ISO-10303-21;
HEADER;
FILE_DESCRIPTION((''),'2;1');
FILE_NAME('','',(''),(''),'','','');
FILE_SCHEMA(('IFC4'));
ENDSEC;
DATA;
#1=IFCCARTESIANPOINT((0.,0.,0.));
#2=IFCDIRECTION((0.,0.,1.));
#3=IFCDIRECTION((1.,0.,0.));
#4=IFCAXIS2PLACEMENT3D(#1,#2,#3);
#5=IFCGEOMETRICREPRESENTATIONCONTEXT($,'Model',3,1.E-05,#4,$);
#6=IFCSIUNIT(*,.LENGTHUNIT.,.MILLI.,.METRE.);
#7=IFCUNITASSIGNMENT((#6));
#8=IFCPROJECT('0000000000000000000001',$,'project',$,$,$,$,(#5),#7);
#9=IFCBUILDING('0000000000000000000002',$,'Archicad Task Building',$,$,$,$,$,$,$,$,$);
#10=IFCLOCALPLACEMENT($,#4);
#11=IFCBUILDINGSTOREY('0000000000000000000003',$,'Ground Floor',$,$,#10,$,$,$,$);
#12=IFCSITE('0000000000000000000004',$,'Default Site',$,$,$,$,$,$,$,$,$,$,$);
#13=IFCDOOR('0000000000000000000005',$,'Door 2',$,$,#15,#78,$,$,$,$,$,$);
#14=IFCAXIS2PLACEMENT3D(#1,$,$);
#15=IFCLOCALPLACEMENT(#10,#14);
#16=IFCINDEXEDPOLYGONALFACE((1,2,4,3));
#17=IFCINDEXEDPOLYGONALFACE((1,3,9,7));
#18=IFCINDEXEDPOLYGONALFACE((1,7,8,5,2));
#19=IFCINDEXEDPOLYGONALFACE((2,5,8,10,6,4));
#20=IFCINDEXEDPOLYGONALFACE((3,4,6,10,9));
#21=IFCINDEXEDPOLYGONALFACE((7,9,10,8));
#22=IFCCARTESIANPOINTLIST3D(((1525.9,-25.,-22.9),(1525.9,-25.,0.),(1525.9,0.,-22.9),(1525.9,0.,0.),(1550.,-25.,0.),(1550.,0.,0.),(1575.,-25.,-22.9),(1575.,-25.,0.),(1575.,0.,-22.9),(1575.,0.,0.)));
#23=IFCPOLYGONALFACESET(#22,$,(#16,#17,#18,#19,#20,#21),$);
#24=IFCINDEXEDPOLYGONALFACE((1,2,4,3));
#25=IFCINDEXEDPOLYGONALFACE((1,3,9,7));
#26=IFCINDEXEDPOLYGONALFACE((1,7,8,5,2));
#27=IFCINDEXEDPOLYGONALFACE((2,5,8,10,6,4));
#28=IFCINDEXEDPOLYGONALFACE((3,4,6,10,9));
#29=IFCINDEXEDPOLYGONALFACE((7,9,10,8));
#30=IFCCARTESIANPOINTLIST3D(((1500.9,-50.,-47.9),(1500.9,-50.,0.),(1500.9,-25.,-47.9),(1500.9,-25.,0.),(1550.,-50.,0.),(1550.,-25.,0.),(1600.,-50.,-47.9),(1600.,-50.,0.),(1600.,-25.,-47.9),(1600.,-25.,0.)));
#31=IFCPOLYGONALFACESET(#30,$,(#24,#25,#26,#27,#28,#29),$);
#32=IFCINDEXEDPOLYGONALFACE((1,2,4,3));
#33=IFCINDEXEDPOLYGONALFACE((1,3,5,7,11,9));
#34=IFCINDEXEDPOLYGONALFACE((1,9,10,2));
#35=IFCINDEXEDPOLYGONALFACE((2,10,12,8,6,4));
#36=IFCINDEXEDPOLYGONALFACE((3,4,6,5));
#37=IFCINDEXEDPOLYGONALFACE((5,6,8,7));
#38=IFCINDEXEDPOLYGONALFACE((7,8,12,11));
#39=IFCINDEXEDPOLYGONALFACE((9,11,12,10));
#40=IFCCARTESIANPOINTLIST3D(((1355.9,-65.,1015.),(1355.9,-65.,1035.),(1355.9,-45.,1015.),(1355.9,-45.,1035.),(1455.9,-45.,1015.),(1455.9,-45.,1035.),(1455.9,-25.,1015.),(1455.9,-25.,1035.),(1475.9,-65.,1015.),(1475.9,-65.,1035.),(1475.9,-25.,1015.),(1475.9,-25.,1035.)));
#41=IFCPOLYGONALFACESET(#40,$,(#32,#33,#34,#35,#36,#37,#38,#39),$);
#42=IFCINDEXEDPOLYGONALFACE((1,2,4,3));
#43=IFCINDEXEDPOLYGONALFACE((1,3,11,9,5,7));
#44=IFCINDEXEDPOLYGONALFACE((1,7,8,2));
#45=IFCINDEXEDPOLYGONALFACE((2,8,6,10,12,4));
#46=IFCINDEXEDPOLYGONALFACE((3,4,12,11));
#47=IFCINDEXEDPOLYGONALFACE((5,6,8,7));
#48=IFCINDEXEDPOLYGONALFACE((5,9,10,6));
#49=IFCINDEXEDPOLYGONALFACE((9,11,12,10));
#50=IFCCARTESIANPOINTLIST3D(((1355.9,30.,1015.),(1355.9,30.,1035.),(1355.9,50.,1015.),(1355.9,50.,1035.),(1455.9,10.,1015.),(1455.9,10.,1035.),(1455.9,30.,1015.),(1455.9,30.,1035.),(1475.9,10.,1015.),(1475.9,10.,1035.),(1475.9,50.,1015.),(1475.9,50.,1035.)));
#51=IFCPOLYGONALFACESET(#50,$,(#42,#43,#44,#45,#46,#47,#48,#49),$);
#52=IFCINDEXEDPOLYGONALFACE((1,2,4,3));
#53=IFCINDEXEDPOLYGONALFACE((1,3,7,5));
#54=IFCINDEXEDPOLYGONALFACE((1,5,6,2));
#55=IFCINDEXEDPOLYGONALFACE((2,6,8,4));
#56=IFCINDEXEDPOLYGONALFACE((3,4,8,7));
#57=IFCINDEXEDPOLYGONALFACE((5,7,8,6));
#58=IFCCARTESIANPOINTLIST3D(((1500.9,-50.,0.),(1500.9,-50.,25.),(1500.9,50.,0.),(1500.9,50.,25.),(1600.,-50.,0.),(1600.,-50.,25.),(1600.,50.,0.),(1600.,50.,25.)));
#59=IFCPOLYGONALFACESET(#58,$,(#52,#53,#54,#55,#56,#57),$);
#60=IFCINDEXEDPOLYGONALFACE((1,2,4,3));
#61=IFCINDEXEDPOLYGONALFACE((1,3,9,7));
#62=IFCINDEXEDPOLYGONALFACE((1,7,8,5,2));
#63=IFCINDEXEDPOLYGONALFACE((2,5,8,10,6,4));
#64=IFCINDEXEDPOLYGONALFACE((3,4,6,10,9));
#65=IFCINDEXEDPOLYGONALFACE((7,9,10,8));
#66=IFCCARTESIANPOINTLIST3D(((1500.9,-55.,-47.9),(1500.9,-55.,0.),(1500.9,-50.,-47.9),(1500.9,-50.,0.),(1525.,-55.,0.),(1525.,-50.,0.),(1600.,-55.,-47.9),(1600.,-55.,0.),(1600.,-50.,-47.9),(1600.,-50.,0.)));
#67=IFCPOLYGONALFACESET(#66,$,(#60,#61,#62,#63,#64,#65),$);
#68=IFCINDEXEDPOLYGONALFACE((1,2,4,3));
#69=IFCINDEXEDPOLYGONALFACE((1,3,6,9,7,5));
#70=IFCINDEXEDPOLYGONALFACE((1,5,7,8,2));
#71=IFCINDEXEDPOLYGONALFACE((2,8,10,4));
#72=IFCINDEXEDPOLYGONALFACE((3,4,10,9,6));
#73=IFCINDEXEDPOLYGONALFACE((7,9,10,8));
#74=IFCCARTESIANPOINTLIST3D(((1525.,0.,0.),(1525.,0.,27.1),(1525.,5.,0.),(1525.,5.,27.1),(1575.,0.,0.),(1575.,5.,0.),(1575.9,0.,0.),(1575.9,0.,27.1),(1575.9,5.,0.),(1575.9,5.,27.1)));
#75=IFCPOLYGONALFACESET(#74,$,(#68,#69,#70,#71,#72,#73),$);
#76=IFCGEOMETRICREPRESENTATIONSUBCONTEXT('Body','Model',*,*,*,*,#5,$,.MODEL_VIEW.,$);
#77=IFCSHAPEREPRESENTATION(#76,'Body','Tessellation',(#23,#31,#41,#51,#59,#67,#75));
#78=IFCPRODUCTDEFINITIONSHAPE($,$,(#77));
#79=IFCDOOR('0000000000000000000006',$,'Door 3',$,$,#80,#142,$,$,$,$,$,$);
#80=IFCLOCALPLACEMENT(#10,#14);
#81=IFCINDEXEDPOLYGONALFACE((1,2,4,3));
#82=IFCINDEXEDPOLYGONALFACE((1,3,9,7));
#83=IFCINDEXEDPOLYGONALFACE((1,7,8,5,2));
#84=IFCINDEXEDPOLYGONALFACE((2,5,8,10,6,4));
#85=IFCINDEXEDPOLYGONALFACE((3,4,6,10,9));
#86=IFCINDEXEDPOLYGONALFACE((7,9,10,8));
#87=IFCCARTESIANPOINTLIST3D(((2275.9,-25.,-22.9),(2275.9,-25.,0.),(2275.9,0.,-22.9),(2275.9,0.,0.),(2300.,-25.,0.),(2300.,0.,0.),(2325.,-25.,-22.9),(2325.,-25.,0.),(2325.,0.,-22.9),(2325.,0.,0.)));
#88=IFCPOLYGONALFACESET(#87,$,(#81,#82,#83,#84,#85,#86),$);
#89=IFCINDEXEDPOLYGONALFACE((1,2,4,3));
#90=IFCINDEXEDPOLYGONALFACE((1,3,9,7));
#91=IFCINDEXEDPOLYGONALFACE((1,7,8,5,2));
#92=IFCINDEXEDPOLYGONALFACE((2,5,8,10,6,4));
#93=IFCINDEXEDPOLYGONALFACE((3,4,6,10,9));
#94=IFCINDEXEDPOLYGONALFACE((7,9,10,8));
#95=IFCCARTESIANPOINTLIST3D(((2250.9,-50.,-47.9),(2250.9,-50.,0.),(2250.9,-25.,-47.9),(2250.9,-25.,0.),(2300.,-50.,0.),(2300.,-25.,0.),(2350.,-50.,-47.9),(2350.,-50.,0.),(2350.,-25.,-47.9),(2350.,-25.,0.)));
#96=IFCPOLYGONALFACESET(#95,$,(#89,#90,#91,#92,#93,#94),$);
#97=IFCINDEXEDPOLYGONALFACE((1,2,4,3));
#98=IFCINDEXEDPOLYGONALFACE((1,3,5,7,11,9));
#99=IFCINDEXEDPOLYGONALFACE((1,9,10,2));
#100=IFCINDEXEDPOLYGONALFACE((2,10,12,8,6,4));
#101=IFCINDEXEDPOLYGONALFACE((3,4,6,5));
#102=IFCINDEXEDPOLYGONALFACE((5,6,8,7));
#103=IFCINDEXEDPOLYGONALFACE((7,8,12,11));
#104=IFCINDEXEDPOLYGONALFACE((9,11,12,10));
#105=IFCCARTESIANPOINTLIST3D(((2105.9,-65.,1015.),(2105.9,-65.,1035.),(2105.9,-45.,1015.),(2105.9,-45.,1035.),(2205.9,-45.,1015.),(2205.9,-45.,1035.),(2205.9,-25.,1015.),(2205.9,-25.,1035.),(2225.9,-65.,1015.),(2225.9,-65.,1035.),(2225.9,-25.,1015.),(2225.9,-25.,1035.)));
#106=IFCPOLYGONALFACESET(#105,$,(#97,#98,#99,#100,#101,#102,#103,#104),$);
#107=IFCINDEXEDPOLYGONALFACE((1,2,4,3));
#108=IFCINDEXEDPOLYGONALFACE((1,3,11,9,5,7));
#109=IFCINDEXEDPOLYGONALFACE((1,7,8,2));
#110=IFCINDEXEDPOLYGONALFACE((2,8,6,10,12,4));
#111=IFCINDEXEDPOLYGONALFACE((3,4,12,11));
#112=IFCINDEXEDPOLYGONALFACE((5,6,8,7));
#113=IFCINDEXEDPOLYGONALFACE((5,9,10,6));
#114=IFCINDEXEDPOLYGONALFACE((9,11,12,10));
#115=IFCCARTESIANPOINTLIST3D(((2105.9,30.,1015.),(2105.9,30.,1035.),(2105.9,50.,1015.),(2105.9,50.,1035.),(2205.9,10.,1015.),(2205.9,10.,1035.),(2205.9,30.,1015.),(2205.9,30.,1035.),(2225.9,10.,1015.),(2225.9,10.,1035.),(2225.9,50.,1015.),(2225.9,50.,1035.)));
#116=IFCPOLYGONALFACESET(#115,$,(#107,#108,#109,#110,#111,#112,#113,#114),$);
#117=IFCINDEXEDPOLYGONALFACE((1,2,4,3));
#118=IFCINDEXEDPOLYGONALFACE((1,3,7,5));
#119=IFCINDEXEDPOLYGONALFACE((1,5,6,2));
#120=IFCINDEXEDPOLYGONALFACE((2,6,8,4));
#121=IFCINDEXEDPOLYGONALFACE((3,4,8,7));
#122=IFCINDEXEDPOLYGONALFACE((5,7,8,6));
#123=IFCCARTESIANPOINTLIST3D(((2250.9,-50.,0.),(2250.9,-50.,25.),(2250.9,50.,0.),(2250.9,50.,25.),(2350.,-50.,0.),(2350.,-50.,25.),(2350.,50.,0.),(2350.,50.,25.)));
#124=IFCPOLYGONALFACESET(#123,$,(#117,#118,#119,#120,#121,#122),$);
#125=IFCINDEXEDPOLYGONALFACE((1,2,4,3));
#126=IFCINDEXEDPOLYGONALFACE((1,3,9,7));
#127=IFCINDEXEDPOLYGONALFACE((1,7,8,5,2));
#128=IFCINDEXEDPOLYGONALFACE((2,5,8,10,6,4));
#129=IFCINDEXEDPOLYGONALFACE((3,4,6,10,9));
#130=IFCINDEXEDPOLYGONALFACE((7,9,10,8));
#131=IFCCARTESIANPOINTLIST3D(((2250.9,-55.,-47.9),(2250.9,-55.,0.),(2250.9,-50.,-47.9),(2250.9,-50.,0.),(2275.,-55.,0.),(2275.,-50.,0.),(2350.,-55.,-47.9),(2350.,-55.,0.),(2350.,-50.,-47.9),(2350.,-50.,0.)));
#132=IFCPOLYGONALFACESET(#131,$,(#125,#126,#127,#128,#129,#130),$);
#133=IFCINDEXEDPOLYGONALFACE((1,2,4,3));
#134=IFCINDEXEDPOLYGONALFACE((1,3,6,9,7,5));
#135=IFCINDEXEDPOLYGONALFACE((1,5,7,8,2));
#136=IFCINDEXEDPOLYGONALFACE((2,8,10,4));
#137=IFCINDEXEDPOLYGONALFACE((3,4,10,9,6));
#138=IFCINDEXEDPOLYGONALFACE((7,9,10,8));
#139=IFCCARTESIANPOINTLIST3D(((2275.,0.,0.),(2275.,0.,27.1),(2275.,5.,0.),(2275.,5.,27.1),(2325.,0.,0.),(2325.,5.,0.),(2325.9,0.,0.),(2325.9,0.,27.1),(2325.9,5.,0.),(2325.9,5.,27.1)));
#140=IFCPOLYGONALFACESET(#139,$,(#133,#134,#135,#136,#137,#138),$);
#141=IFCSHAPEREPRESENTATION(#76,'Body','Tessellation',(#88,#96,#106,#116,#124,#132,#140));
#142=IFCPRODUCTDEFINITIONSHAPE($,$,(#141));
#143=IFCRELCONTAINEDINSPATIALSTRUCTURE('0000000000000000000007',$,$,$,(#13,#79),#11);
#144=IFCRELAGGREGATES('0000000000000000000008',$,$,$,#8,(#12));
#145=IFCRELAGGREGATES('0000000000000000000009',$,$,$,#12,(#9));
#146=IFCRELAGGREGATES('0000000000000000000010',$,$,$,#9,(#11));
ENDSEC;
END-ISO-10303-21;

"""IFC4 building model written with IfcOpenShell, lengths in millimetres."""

from ifc_helpers import new_model, si_unit, frame, origin_with_axes, place, context, subcontext, project, spatial, line, indexed_curve, outline, extrude, element, save


model = new_model("IFC4")

# Units and contexts
model_context = context("Model", 3, precision=1e-05, world=origin_with_axes())
body_context = subcontext(model_context, "Body", "Model", "MODEL_VIEW")
ifc_project = project(units=[si_unit("LENGTHUNIT", "METRE", prefix="MILLI")], contexts=[model_context])

# Site, building, storey
site = spatial("IfcSite", under=ifc_project, Name="Default Site")
building = spatial("IfcBuilding", under=site, Name="Archicad Task Building")
storey_placement = place(None, origin_with_axes())
storey = spatial("IfcBuildingStorey", under=building, at=storey_placement, Name="Ground Floor")

# Doors
door_1_placement = place(storey_placement, frame((1550.0, -50.0, 0.0), z_axis=(0.0, 0.0, 1.0), x_axis=(1.0, 0.0, 0.0)))
element("IfcDoor", 1, at=door_1_placement, inside=storey, Name="Door 2", context=body_context, shape_type="SweptSolid", body=[
    extrude(outline(indexed_curve([(0.0, 0.0), (0.0, 2.1), (0.9, 2.1), (0.9, 0.0), (-24.1, 0.0), (-24.1, -22.9), (25.0, -22.9), (25.0, 0.0)], segments=[line(1, 2, 3, 4, 5, 6, 7, 8, 1)])), frame((0.0, 25.0, 0.0), z_axis=(0.0, -1.0, 0.0), x_axis=(1.0, 0.0, 0.0)), (0.0, 0.0, -1.0), 25.0),
    extrude(outline(indexed_curve([(0.0, 0.0), (0.0, 2.1), (0.9, 2.1), (0.9, 0.0), (-49.1, 0.0), (-49.1, -47.9), (50.0, -47.9), (50.0, 0.0)], segments=[line(1, 2, 3, 4, 5, 6, 7, 8, 1)])), frame((0.0, 0.0, 0.0), z_axis=(0.0, -1.0, 0.0), x_axis=(1.0, 0.0, 0.0)), (0.0, 0.0, -1.0), 25.0),
    extrude(outline(indexed_curve([(0.0, 0.0), (-49.1, 0.0), (-49.1, 35.0), (0.0, 35.0)], segments=[line(1, 2, 3, 4, 1)])), frame((25.0, 25.0, 25.0), z_axis=(0.0, 0.0, 1.0), x_axis=(1.0, 0.0, 0.0)), (0.0, 0.0, 1.0), -47.9),
    extrude(outline(indexed_curve([(0.0, 0.0), (0.0, -40.0), (-120.0, -40.0), (-120.0, -20.0), (-20.0, -20.0), (-20.0, 0.0)], segments=[line(1, 2, 3, 4, 5, 6, 1)])), frame((-74.1, 25.0, 1015.0), z_axis=(0.0, 0.0, 1.0), x_axis=(1.0, 0.0, 0.0)), (0.0, 0.0, 1.0), 20.0),
    extrude(outline(indexed_curve([(0.0, 0.0), (0.0, 40.0), (-120.0, 40.0), (-120.0, 20.0), (-20.0, 20.0), (-20.0, 0.0)], segments=[line(1, 2, 3, 4, 5, 6, 1)])), frame((-74.1, 60.0, 1015.0), z_axis=(0.0, 0.0, 1.0), x_axis=(1.0, 0.0, 0.0)), (0.0, 0.0, 1.0), 20.0),
    extrude(outline(indexed_curve([(0.0, 0.0), (-99.1, 0.0), (-99.1, 100.0), (0.0, 100.0)], segments=[line(1, 2, 3, 4, 1)])), frame((50.0, 0.0, 0.0), z_axis=(0.0, 0.0, 1.0), x_axis=(1.0, 0.0, 0.0)), (0.0, 0.0, 1.0), 25.0),
    extrude(outline(indexed_curve([(0.0, 0.0), (0.0, 27.1), (50.9, 27.1), (50.9, 0.0), (-24.1, 0.0), (-24.1, -47.9), (75.0, -47.9), (75.0, 0.0)], segments=[line(1, 2, 3, 4, 5, 6, 7, 8, 1)])), frame((-25.0, -5.0, 0.0), z_axis=(0.0, -1.0, 0.0), x_axis=(1.0, 0.0, 0.0)), (0.0, 0.0, -1.0), 5.0),
    extrude(outline(indexed_curve([(0.0, 0.0), (0.0, 27.1), (50.9, 27.1), (50.9, 0.0), (0.9, 0.0), (0.9, -22.9), (50.0, -22.9), (50.0, 0.0)], segments=[line(1, 2, 3, 4, 5, 6, 7, 8, 1)])), frame((-25.0, 50.0, 0.0), z_axis=(0.0, -1.0, 0.0), x_axis=(1.0, 0.0, 0.0)), (0.0, 0.0, -1.0), 5.0),
])
door_2_placement = place(storey_placement, frame((2300.0, -50.0, 0.0), z_axis=(0.0, 0.0, 1.0), x_axis=(1.0, 0.0, 0.0)))
element("IfcDoor", 2, at=door_2_placement, inside=storey, Name="Door 3", context=body_context, shape_type="SweptSolid", body=[
    extrude(outline(indexed_curve([(0.0, 0.0), (0.0, 2.1), (0.9, 2.1), (0.9, 0.0), (-24.1, 0.0), (-24.1, -22.9), (25.0, -22.9), (25.0, 0.0)], segments=[line(1, 2, 3, 4, 5, 6, 7, 8, 1)])), frame((0.0, 25.0, 0.0), z_axis=(0.0, -1.0, 0.0), x_axis=(1.0, 0.0, 0.0)), (0.0, 0.0, -1.0), 25.0),
    extrude(outline(indexed_curve([(0.0, 0.0), (0.0, 2.1), (0.9, 2.1), (0.9, 0.0), (-49.1, 0.0), (-49.1, -47.9), (50.0, -47.9), (50.0, 0.0)], segments=[line(1, 2, 3, 4, 5, 6, 7, 8, 1)])), frame((0.0, 0.0, 0.0), z_axis=(0.0, -1.0, 0.0), x_axis=(1.0, 0.0, 0.0)), (0.0, 0.0, -1.0), 25.0),
    extrude(outline(indexed_curve([(0.0, 0.0), (-49.1, 0.0), (-49.1, 35.0), (0.0, 35.0)], segments=[line(1, 2, 3, 4, 1)])), frame((25.0, 25.0, 25.0), z_axis=(0.0, 0.0, 1.0), x_axis=(1.0, 0.0, 0.0)), (0.0, 0.0, 1.0), -47.9),
    extrude(outline(indexed_curve([(0.0, 0.0), (0.0, -40.0), (-120.0, -40.0), (-120.0, -20.0), (-20.0, -20.0), (-20.0, 0.0)], segments=[line(1, 2, 3, 4, 5, 6, 1)])), frame((-74.1, 25.0, 1015.0), z_axis=(0.0, 0.0, 1.0), x_axis=(1.0, 0.0, 0.0)), (0.0, 0.0, 1.0), 20.0),
    extrude(outline(indexed_curve([(0.0, 0.0), (0.0, 40.0), (-120.0, 40.0), (-120.0, 20.0), (-20.0, 20.0), (-20.0, 0.0)], segments=[line(1, 2, 3, 4, 5, 6, 1)])), frame((-74.1, 60.0, 1015.0), z_axis=(0.0, 0.0, 1.0), x_axis=(1.0, 0.0, 0.0)), (0.0, 0.0, 1.0), 20.0),
    extrude(outline(indexed_curve([(0.0, 0.0), (-99.1, 0.0), (-99.1, 100.0), (0.0, 100.0)], segments=[line(1, 2, 3, 4, 1)])), frame((50.0, 0.0, 0.0), z_axis=(0.0, 0.0, 1.0), x_axis=(1.0, 0.0, 0.0)), (0.0, 0.0, 1.0), 25.0),
    extrude(outline(indexed_curve([(0.0, 0.0), (0.0, 27.1), (50.9, 27.1), (50.9, 0.0), (-24.1, 0.0), (-24.1, -47.9), (75.0, -47.9), (75.0, 0.0)], segments=[line(1, 2, 3, 4, 5, 6, 7, 8, 1)])), frame((-25.0, -5.0, 0.0), z_axis=(0.0, -1.0, 0.0), x_axis=(1.0, 0.0, 0.0)), (0.0, 0.0, -1.0), 5.0),
    extrude(outline(indexed_curve([(0.0, 0.0), (0.0, 27.1), (50.9, 27.1), (50.9, 0.0), (0.9, 0.0), (0.9, -22.9), (50.0, -22.9), (50.0, 0.0)], segments=[line(1, 2, 3, 4, 5, 6, 7, 8, 1)])), frame((-25.0, 50.0, 0.0), z_axis=(0.0, -1.0, 0.0), x_axis=(1.0, 0.0, 0.0)), (0.0, 0.0, -1.0), 5.0),
])

save(model, "model.ifc")
